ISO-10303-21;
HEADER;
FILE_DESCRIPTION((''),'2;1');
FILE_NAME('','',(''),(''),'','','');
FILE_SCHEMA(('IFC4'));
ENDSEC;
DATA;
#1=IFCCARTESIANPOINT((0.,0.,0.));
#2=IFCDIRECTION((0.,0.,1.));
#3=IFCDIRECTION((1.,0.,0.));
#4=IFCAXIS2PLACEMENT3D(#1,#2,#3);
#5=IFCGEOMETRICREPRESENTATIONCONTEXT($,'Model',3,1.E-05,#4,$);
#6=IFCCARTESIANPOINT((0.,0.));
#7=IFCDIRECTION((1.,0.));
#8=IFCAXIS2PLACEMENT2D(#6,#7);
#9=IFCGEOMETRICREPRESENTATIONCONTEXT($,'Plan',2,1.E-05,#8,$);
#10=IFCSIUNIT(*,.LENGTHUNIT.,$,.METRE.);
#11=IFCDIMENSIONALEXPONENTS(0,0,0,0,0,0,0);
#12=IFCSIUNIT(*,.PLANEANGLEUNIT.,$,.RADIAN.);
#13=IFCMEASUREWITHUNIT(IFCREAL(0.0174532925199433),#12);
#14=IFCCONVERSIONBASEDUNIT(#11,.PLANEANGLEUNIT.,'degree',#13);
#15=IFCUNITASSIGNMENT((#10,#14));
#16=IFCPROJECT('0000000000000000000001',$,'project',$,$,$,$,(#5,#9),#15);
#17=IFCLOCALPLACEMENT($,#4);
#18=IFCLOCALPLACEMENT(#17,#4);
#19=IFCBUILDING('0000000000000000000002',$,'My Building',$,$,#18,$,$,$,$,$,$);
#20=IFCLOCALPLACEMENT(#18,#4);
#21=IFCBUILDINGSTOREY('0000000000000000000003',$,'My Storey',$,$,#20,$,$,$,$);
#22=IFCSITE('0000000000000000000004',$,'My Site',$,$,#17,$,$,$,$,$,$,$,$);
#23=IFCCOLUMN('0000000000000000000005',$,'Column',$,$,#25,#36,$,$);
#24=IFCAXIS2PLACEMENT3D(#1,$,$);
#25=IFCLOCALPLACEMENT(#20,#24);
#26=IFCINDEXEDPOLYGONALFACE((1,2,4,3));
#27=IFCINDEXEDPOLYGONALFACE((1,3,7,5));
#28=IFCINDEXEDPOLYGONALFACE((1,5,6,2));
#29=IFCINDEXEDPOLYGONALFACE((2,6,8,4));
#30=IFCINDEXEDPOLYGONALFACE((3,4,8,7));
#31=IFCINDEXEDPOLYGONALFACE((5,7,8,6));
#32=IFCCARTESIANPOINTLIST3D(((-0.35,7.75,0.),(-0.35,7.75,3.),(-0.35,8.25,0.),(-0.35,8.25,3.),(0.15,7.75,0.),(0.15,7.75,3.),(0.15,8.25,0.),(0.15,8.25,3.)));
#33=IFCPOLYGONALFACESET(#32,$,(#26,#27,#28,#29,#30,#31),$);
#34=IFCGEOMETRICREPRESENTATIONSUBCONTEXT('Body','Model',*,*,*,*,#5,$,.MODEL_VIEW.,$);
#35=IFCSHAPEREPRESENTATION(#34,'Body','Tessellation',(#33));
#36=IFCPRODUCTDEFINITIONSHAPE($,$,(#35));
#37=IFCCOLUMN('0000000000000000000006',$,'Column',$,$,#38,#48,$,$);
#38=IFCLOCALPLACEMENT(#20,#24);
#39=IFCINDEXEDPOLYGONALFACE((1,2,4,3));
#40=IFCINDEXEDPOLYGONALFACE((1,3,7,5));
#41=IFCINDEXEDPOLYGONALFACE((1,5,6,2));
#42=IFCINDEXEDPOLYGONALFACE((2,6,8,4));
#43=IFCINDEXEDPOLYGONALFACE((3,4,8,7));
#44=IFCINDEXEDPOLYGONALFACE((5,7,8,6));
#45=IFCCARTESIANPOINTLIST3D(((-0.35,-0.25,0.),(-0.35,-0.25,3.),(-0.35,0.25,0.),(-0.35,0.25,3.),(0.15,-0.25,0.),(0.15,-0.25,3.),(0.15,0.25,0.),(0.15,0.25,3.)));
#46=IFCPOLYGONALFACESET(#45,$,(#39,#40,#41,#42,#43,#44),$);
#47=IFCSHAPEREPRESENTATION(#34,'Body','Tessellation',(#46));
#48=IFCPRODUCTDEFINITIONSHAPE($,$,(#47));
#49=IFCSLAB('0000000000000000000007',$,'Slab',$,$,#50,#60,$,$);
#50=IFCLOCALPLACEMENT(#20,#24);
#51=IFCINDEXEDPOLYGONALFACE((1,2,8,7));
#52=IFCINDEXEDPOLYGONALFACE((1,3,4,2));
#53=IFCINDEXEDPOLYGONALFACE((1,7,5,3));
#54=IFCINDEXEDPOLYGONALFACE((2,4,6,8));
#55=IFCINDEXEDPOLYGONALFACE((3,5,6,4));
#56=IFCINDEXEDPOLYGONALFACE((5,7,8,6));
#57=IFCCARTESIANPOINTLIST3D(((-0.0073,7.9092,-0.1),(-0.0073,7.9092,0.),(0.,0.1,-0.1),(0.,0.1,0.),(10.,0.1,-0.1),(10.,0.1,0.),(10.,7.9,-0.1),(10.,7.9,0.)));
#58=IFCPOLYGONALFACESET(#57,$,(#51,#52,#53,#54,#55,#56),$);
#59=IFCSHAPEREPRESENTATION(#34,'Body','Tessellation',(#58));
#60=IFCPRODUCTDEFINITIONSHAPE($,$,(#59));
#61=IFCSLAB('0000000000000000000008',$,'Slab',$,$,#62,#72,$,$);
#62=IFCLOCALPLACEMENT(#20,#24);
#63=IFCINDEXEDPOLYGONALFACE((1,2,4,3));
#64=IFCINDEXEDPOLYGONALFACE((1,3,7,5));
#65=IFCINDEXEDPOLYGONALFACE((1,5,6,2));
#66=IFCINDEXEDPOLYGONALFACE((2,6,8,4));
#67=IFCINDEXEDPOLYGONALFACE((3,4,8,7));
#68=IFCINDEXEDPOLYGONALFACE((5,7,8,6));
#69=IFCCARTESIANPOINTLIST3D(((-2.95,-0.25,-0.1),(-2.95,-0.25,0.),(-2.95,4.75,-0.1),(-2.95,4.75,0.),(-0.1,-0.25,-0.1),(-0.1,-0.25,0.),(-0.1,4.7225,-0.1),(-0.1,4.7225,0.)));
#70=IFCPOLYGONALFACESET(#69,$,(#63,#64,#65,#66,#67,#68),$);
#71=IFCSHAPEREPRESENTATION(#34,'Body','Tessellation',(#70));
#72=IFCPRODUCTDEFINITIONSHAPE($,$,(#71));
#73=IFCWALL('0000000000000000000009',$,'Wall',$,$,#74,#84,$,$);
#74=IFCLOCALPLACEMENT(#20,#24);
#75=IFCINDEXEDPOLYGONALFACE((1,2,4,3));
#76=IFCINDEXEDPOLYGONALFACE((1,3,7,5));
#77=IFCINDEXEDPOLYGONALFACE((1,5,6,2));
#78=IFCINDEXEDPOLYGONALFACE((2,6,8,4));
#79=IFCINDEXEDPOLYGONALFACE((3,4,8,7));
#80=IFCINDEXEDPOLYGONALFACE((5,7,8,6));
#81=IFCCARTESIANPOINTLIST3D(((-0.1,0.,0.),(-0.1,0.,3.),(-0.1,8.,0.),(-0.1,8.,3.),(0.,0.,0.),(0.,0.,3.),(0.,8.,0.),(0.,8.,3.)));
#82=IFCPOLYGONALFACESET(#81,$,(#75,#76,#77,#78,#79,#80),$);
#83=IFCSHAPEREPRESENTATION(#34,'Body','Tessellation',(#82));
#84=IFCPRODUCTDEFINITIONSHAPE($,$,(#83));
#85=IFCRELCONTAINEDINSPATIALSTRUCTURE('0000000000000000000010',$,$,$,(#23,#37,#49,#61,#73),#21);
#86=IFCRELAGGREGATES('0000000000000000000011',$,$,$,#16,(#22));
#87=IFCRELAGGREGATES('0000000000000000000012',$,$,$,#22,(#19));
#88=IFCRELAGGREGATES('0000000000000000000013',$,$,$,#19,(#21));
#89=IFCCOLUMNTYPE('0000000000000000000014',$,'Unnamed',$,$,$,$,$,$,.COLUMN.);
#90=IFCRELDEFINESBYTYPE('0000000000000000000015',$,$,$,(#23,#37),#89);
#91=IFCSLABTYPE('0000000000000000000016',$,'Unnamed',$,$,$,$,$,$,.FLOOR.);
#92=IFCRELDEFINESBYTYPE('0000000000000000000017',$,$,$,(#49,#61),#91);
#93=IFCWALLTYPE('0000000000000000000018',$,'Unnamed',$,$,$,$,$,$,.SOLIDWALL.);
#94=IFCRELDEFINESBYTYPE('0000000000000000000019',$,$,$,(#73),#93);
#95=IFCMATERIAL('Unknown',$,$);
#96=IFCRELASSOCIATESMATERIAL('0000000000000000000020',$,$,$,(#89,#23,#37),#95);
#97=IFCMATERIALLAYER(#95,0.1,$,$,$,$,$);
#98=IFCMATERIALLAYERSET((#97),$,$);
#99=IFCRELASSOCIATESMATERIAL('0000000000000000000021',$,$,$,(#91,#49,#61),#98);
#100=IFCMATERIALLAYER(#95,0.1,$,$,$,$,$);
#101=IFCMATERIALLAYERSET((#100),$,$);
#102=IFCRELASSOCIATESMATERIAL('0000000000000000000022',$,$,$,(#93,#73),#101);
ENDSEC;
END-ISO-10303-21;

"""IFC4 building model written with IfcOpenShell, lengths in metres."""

from ifc_helpers import new_model, entity, si_unit, converted_unit, frame, origin_with_axes, origin_2d_with_axis, place, context, subcontext, project, spatial, line, indexed_curve, rectangle, outline, extrude, material, layer, layer_set, layer_usage, material_profile, profile_set, profile_usage, type_object, element, save


model = new_model("IFC4")

# Units and contexts
model_context = context("Model", 3, precision=1e-05, world=origin_with_axes())
plan_context = context("Plan", 2, precision=1e-05, world=origin_2d_with_axis())
body_context_1 = subcontext(model_context, "Body", "Model", "MODEL_VIEW")
ifc_project = project(units=[si_unit("LENGTHUNIT", "METRE"), converted_unit("PLANEANGLEUNIT", "degree", entity("IfcReal", 0.0174532925199433), si_unit("PLANEANGLEUNIT", "RADIAN"), dimensions=[0, 0, 0, 0, 0, 0, 0])], contexts=[model_context, plan_context])

# Site, building, storey
site_placement = place(None, origin_with_axes())
site = spatial("IfcSite", under=ifc_project, at=site_placement, Name="My Site")
building_placement = place(site_placement, origin_with_axes())
building = spatial("IfcBuilding", under=site, at=building_placement, Name="My Building")
storey_placement = place(building_placement, origin_with_axes())
storey = spatial("IfcBuildingStorey", under=building, at=storey_placement, Name="My Storey")

# Columns
ifc_material = material(Name="Unknown")
ifc_material_profile = material_profile(ifc_material, rectangle(XDim=0.5, YDim=0.5))
ifc_profile_set = profile_set([ifc_material_profile])
ifc_profile_usage_1 = profile_usage(ifc_profile_set, cardinal=5)
column_type = type_object("IfcColumnType", Name="Unnamed", PredefinedType="COLUMN", material=ifc_profile_set)
column_1_placement = place(storey_placement, frame((-0.1, 8.0, 0.0), z_axis=(0.0, 0.0, 1.0), x_axis=(1.0, 0.0, 0.0)))
element("IfcColumn", 1, at=column_1_placement, inside=storey, type_object=column_type, material=ifc_profile_usage_1, Name="Column", context=body_context_1, shape_type="SweptSolid", body=[
    extrude(rectangle(XDim=0.5, YDim=0.5), origin_with_axes(), (0.0, 0.0, 1.0), 3.0),
])
ifc_profile_usage_2 = profile_usage(ifc_profile_set, cardinal=5)
column_2_placement = place(storey_placement, frame((-0.1, 0.0, 0.0), z_axis=(0.0, 0.0, 1.0), x_axis=(1.0, 0.0, 0.0)))
element("IfcColumn", 2, at=column_2_placement, inside=storey, type_object=column_type, material=ifc_profile_usage_2, Name="Column", context=body_context_1, shape_type="SweptSolid", body=[
    extrude(rectangle(XDim=0.5, YDim=0.5), origin_with_axes(), (0.0, 0.0, 1.0), 3.0),
])

# Slabs
ifc_layer_1 = layer(ifc_material, 0.1)
ifc_layer_set_1 = layer_set([ifc_layer_1])
ifc_layer_usage_1 = layer_usage(ifc_layer_set_1, "AXIS3", "POSITIVE", -0.1)
slab_type = type_object("IfcSlabType", Name="Unnamed", PredefinedType="FLOOR", material=ifc_layer_set_1)
slab_1_placement = place(storey_placement, frame((-0.0073, 7.9092, 0.0), z_axis=(0.0, 0.0, 1.0), x_axis=(1.0, 0.0, 0.0)))
element("IfcSlab", 3, at=slab_1_placement, inside=storey, type_object=slab_type, material=ifc_layer_usage_1, Name="Slab", context=body_context_1, shape_type="SweptSolid", body=[
    extrude(outline(indexed_curve([(0.0, 0.0), (0.0073, -7.8092), (10.0073, -7.8092), (10.0073, -0.0092), (0.0, 0.0)])), frame((0.0, 0.0, -0.1), z_axis=(0.0, 0.0, 1.0), x_axis=(1.0, 0.0, 0.0)), (0.0, 0.0, 1.0), 0.1),
])
ifc_layer_usage_2 = layer_usage(ifc_layer_set_1, "AXIS3", "POSITIVE", -0.1)
slab_2_placement = place(storey_placement, frame((-2.95, 4.75, 0.0), z_axis=(0.0, 0.0, 1.0), x_axis=(1.0, 0.0, 0.0)))
element("IfcSlab", 4, at=slab_2_placement, inside=storey, type_object=slab_type, material=ifc_layer_usage_2, Name="Slab", context=body_context_1, shape_type="SweptSolid", body=[
    extrude(outline(indexed_curve([(0.0, 0.0), (0.0, -5.0), (2.85, -5.0), (2.85, -0.0275), (0.0, 0.0)])), frame((0.0, 0.0, -0.1), z_axis=(0.0, 0.0, 1.0), x_axis=(1.0, 0.0, 0.0)), (0.0, 0.0, 1.0), 0.1),
])

# Shared definitions
ifc_layer_2 = layer(ifc_material, 0.1)
ifc_layer_set_2 = layer_set([ifc_layer_2])
wall_type = type_object("IfcWallType", Name="Unnamed", PredefinedType="SOLIDWALL", material=ifc_layer_set_2)

# Wall
ifc_layer_usage_3 = layer_usage(ifc_layer_set_2, "AXIS2", "POSITIVE", 0.0)
wall_1_placement = place(storey_placement, frame((0.0, 0.0, 0.0), z_axis=(0.0, 0.0, 1.0), x_axis=(0.0, 1.0, 0.0)))
element("IfcWall", 5, at=wall_1_placement, inside=storey, type_object=wall_type, material=ifc_layer_usage_3, Name="Wall", context=body_context_1, shape_type="SweptSolid", body=[
    extrude(outline(indexed_curve([(0.0, 0.0), (0.0, 0.1), (8.0, 0.1), (8.0, 0.0)], segments=[line(1, 2, 3, 4, 1)])), origin_with_axes(), (0.0, 0.0, 1.0), 3.0),
])

save(model, "model.ifc")
